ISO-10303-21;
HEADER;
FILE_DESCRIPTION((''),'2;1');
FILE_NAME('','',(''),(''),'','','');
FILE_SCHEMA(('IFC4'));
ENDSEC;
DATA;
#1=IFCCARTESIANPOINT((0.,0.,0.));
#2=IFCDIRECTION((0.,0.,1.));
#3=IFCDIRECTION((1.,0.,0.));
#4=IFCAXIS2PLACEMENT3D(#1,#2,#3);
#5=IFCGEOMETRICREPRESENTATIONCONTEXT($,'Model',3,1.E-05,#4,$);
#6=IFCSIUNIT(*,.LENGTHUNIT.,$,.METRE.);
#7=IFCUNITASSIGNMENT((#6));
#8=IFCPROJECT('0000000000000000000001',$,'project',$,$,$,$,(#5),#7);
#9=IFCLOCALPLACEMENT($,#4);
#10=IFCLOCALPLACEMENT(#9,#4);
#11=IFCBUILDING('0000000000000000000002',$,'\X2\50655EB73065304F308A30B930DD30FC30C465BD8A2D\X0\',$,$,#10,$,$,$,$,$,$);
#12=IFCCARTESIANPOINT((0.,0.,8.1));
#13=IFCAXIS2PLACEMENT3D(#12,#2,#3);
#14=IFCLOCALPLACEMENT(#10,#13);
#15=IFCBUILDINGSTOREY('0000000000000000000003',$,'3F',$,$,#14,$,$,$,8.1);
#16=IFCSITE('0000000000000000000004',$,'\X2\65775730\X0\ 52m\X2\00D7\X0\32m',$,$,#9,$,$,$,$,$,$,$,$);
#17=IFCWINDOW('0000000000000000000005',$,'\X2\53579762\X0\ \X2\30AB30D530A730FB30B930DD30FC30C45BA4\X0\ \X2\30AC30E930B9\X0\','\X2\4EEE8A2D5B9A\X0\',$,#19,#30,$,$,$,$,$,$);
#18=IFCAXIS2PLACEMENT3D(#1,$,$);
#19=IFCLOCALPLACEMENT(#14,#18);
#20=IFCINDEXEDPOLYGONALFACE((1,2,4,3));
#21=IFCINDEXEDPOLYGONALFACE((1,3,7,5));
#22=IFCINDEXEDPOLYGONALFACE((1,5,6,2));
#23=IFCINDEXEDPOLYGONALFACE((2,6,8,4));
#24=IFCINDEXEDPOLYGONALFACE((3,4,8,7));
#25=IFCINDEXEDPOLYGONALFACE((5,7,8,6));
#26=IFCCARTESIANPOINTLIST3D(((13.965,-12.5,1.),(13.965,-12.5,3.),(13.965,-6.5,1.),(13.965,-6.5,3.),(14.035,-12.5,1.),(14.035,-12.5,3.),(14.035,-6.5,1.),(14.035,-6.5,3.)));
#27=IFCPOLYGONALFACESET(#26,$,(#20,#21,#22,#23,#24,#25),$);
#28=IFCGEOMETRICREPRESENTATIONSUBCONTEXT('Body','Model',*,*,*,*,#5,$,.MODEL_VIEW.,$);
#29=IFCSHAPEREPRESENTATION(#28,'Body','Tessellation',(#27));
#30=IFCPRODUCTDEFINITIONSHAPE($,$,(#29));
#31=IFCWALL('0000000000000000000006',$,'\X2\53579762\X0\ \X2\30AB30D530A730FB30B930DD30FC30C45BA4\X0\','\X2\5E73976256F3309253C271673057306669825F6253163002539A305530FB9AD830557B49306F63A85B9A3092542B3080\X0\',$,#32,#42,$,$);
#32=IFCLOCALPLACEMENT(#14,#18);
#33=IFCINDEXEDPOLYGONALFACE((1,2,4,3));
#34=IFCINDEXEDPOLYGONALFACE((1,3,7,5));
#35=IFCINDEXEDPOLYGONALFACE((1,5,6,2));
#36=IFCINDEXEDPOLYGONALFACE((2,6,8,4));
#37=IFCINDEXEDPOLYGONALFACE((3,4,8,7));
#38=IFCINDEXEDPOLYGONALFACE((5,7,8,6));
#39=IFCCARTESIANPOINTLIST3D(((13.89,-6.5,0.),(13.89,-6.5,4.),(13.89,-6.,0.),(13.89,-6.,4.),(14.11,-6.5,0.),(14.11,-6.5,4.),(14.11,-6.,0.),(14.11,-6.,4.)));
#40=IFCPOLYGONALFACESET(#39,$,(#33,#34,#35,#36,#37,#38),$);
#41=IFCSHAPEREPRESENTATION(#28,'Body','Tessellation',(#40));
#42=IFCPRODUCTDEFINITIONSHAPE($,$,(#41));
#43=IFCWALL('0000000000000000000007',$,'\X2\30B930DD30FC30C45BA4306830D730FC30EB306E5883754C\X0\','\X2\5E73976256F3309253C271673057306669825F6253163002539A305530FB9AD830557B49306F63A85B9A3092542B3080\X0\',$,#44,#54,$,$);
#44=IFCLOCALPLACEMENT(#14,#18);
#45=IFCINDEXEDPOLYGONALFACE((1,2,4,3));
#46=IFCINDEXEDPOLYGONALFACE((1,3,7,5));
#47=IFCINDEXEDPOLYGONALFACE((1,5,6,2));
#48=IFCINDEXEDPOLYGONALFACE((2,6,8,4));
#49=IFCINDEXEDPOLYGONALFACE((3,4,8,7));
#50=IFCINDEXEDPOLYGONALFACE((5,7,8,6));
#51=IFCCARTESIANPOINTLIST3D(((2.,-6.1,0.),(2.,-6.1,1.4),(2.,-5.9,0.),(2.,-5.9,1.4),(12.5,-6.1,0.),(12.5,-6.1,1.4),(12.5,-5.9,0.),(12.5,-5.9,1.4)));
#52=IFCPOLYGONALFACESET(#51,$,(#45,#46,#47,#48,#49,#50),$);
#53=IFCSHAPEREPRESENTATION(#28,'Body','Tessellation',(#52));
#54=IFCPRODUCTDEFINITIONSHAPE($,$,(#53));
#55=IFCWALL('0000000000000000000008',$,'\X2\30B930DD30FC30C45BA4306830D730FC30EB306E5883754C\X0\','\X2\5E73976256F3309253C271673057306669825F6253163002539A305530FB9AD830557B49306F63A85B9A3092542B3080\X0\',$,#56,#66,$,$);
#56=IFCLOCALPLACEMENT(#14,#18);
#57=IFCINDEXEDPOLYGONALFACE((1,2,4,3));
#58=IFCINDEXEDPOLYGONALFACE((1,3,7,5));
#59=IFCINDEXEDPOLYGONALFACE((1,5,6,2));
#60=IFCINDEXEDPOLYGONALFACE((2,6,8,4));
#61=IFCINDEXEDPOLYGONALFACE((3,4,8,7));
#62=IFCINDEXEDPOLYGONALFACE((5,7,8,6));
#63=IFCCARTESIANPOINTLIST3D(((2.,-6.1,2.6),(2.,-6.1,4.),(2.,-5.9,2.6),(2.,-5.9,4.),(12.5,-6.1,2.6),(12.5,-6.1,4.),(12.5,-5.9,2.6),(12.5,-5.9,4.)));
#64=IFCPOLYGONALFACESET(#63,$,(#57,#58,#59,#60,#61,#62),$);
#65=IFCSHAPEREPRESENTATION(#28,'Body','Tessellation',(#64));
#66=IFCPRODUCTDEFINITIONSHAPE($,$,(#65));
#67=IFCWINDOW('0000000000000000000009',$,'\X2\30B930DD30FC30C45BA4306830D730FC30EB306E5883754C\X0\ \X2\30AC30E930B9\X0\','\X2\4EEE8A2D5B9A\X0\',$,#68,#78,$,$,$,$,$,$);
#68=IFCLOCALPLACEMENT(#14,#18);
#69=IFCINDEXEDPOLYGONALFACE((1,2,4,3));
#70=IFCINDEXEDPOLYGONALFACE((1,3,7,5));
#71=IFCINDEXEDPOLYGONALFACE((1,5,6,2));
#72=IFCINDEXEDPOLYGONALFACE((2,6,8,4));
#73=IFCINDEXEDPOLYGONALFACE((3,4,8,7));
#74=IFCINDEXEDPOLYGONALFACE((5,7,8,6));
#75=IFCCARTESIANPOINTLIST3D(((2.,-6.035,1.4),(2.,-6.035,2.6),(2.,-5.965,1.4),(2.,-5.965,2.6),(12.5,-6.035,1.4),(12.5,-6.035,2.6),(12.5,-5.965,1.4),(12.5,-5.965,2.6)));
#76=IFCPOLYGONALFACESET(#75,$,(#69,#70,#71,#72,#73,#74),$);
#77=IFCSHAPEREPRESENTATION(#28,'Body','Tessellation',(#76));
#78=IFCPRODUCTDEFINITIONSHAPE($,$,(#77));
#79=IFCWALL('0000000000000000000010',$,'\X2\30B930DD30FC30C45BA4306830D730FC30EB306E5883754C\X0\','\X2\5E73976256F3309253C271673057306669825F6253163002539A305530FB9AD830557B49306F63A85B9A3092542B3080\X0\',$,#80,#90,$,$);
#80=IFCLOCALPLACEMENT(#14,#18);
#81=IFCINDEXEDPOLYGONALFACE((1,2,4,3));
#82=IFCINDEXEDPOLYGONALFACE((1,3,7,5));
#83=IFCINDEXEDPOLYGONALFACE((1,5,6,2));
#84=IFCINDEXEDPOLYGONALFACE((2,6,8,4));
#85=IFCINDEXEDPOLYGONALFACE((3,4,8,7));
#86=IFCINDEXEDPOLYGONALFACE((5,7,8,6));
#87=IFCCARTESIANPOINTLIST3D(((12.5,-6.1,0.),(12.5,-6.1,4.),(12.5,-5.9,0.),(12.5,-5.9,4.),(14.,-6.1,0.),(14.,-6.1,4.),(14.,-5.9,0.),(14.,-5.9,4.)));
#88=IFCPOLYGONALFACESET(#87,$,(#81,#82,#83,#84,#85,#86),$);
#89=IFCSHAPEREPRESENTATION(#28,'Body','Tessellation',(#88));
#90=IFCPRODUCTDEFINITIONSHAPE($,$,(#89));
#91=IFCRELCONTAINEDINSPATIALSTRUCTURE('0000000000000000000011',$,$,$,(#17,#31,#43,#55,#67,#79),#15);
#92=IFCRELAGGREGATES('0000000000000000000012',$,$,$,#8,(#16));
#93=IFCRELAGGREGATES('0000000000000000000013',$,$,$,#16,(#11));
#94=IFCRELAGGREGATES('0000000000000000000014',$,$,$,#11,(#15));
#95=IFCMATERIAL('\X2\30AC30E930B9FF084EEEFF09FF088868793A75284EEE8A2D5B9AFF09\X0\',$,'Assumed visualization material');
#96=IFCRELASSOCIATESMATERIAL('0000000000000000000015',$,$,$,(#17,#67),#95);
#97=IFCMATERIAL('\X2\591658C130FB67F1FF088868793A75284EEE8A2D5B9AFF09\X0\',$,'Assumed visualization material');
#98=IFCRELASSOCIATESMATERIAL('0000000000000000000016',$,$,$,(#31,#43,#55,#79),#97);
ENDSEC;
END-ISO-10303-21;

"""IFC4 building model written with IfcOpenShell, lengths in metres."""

from ifc_helpers import new_model, si_unit, frame, origin_with_axes, place, context, subcontext, project, spatial, rectangle, extrude, material, element, save


model = new_model("IFC4")

# Units and contexts
model_context = context("Model", 3, precision=1e-05, world=origin_with_axes())
body_context = subcontext(model_context, "Body", "Model", "MODEL_VIEW")
ifc_project = project(units=[si_unit("LENGTHUNIT", "METRE")], contexts=[model_context])

# Site, building, storey
site_placement = place(None, origin_with_axes())
site = spatial("IfcSite", under=ifc_project, at=site_placement, Name="敷地 52m×32m")
building_placement = place(site_placement, origin_with_axes())
building = spatial("IfcBuilding", under=site, at=building_placement, Name="健康づくりスポーツ施設")
storey_placement = place(building_placement, frame((0.0, 0.0, 8.1), z_axis=(0.0, 0.0, 1.0), x_axis=(1.0, 0.0, 0.0)))
storey = spatial("IfcBuildingStorey", under=building, at=storey_placement, Name="3F", Elevation=8.1)

# Shared definitions
ifc_material_1 = material(Name="外壁・柱（表示用仮設定）", Category="Assumed visualization material")

# Window
ifc_material_2 = material(Name="ガラス（仮）（表示用仮設定）", Category="Assumed visualization material")
window_1_placement = place(storey_placement, frame((14.0, -9.5, 1.0), z_axis=(0.0, 0.0, 1.0), x_axis=(1.0, 0.0, 0.0)))
element("IfcWindow", 1, at=window_1_placement, inside=storey, material=ifc_material_2, Name="南面 カフェ・スポーツ室 ガラス", Description="仮設定", context=body_context, shape_type="SweptSolid", body=[
    extrude(rectangle(XDim=0.07, YDim=6.0), origin_with_axes(), (0.0, 0.0, 1.0), 2.0),
])

# Walls
wall_1_placement = place(storey_placement, frame((14.0, -6.25, 0.0), z_axis=(0.0, 0.0, 1.0), x_axis=(1.0, 0.0, 0.0)))
element("IfcWall", 2, at=wall_1_placement, inside=storey, material=ifc_material_1, Name="南面 カフェ・スポーツ室", Description="平面図を参照して概形化。厚さ・高さ等は推定を含む", context=body_context, shape_type="SweptSolid", body=[
    extrude(rectangle(XDim=0.22, YDim=0.5), origin_with_axes(), (0.0, 0.0, 1.0), 4.0),
])
for number, where, z_axis, x_axis, name in (
    (3, (7.25, -6.0, 0.0), (0.0, 0.0, 1.0), (1.0, 0.0, 0.0), "スポーツ室とプールの境界"),
    (4, (7.25, -6.0, 2.6), (0.0, 0.0, 1.0), (1.0, 0.0, 0.0), "スポーツ室とプールの境界"),
):
    element("IfcWall", number, at=place(storey_placement, frame(where, z_axis=z_axis, x_axis=x_axis)), inside=storey, material=ifc_material_1, Name=name, Description="平面図を参照して概形化。厚さ・高さ等は推定を含む", context=body_context, shape_type="SweptSolid", body=[
        extrude(rectangle(XDim=10.5, YDim=0.2), origin_with_axes(), (0.0, 0.0, 1.0), 1.4),
    ])

# Window
window_2_placement = place(storey_placement, frame((7.25, -6.0, 1.4), z_axis=(0.0, 0.0, 1.0), x_axis=(1.0, 0.0, 0.0)))
element("IfcWindow", 5, at=window_2_placement, inside=storey, material=ifc_material_2, Name="スポーツ室とプールの境界 ガラス", Description="仮設定", context=body_context, shape_type="SweptSolid", body=[
    extrude(rectangle(XDim=10.5, YDim=0.07), origin_with_axes(), (0.0, 0.0, 1.0), 1.2),
])

# Wall
wall_2_placement = place(storey_placement, frame((13.25, -6.0, 0.0), z_axis=(0.0, 0.0, 1.0), x_axis=(1.0, 0.0, 0.0)))
element("IfcWall", 6, at=wall_2_placement, inside=storey, material=ifc_material_1, Name="スポーツ室とプールの境界", Description="平面図を参照して概形化。厚さ・高さ等は推定を含む", context=body_context, shape_type="SweptSolid", body=[
    extrude(rectangle(XDim=1.5, YDim=0.2), origin_with_axes(), (0.0, 0.0, 1.0), 4.0),
])

save(model, "model.ifc")
